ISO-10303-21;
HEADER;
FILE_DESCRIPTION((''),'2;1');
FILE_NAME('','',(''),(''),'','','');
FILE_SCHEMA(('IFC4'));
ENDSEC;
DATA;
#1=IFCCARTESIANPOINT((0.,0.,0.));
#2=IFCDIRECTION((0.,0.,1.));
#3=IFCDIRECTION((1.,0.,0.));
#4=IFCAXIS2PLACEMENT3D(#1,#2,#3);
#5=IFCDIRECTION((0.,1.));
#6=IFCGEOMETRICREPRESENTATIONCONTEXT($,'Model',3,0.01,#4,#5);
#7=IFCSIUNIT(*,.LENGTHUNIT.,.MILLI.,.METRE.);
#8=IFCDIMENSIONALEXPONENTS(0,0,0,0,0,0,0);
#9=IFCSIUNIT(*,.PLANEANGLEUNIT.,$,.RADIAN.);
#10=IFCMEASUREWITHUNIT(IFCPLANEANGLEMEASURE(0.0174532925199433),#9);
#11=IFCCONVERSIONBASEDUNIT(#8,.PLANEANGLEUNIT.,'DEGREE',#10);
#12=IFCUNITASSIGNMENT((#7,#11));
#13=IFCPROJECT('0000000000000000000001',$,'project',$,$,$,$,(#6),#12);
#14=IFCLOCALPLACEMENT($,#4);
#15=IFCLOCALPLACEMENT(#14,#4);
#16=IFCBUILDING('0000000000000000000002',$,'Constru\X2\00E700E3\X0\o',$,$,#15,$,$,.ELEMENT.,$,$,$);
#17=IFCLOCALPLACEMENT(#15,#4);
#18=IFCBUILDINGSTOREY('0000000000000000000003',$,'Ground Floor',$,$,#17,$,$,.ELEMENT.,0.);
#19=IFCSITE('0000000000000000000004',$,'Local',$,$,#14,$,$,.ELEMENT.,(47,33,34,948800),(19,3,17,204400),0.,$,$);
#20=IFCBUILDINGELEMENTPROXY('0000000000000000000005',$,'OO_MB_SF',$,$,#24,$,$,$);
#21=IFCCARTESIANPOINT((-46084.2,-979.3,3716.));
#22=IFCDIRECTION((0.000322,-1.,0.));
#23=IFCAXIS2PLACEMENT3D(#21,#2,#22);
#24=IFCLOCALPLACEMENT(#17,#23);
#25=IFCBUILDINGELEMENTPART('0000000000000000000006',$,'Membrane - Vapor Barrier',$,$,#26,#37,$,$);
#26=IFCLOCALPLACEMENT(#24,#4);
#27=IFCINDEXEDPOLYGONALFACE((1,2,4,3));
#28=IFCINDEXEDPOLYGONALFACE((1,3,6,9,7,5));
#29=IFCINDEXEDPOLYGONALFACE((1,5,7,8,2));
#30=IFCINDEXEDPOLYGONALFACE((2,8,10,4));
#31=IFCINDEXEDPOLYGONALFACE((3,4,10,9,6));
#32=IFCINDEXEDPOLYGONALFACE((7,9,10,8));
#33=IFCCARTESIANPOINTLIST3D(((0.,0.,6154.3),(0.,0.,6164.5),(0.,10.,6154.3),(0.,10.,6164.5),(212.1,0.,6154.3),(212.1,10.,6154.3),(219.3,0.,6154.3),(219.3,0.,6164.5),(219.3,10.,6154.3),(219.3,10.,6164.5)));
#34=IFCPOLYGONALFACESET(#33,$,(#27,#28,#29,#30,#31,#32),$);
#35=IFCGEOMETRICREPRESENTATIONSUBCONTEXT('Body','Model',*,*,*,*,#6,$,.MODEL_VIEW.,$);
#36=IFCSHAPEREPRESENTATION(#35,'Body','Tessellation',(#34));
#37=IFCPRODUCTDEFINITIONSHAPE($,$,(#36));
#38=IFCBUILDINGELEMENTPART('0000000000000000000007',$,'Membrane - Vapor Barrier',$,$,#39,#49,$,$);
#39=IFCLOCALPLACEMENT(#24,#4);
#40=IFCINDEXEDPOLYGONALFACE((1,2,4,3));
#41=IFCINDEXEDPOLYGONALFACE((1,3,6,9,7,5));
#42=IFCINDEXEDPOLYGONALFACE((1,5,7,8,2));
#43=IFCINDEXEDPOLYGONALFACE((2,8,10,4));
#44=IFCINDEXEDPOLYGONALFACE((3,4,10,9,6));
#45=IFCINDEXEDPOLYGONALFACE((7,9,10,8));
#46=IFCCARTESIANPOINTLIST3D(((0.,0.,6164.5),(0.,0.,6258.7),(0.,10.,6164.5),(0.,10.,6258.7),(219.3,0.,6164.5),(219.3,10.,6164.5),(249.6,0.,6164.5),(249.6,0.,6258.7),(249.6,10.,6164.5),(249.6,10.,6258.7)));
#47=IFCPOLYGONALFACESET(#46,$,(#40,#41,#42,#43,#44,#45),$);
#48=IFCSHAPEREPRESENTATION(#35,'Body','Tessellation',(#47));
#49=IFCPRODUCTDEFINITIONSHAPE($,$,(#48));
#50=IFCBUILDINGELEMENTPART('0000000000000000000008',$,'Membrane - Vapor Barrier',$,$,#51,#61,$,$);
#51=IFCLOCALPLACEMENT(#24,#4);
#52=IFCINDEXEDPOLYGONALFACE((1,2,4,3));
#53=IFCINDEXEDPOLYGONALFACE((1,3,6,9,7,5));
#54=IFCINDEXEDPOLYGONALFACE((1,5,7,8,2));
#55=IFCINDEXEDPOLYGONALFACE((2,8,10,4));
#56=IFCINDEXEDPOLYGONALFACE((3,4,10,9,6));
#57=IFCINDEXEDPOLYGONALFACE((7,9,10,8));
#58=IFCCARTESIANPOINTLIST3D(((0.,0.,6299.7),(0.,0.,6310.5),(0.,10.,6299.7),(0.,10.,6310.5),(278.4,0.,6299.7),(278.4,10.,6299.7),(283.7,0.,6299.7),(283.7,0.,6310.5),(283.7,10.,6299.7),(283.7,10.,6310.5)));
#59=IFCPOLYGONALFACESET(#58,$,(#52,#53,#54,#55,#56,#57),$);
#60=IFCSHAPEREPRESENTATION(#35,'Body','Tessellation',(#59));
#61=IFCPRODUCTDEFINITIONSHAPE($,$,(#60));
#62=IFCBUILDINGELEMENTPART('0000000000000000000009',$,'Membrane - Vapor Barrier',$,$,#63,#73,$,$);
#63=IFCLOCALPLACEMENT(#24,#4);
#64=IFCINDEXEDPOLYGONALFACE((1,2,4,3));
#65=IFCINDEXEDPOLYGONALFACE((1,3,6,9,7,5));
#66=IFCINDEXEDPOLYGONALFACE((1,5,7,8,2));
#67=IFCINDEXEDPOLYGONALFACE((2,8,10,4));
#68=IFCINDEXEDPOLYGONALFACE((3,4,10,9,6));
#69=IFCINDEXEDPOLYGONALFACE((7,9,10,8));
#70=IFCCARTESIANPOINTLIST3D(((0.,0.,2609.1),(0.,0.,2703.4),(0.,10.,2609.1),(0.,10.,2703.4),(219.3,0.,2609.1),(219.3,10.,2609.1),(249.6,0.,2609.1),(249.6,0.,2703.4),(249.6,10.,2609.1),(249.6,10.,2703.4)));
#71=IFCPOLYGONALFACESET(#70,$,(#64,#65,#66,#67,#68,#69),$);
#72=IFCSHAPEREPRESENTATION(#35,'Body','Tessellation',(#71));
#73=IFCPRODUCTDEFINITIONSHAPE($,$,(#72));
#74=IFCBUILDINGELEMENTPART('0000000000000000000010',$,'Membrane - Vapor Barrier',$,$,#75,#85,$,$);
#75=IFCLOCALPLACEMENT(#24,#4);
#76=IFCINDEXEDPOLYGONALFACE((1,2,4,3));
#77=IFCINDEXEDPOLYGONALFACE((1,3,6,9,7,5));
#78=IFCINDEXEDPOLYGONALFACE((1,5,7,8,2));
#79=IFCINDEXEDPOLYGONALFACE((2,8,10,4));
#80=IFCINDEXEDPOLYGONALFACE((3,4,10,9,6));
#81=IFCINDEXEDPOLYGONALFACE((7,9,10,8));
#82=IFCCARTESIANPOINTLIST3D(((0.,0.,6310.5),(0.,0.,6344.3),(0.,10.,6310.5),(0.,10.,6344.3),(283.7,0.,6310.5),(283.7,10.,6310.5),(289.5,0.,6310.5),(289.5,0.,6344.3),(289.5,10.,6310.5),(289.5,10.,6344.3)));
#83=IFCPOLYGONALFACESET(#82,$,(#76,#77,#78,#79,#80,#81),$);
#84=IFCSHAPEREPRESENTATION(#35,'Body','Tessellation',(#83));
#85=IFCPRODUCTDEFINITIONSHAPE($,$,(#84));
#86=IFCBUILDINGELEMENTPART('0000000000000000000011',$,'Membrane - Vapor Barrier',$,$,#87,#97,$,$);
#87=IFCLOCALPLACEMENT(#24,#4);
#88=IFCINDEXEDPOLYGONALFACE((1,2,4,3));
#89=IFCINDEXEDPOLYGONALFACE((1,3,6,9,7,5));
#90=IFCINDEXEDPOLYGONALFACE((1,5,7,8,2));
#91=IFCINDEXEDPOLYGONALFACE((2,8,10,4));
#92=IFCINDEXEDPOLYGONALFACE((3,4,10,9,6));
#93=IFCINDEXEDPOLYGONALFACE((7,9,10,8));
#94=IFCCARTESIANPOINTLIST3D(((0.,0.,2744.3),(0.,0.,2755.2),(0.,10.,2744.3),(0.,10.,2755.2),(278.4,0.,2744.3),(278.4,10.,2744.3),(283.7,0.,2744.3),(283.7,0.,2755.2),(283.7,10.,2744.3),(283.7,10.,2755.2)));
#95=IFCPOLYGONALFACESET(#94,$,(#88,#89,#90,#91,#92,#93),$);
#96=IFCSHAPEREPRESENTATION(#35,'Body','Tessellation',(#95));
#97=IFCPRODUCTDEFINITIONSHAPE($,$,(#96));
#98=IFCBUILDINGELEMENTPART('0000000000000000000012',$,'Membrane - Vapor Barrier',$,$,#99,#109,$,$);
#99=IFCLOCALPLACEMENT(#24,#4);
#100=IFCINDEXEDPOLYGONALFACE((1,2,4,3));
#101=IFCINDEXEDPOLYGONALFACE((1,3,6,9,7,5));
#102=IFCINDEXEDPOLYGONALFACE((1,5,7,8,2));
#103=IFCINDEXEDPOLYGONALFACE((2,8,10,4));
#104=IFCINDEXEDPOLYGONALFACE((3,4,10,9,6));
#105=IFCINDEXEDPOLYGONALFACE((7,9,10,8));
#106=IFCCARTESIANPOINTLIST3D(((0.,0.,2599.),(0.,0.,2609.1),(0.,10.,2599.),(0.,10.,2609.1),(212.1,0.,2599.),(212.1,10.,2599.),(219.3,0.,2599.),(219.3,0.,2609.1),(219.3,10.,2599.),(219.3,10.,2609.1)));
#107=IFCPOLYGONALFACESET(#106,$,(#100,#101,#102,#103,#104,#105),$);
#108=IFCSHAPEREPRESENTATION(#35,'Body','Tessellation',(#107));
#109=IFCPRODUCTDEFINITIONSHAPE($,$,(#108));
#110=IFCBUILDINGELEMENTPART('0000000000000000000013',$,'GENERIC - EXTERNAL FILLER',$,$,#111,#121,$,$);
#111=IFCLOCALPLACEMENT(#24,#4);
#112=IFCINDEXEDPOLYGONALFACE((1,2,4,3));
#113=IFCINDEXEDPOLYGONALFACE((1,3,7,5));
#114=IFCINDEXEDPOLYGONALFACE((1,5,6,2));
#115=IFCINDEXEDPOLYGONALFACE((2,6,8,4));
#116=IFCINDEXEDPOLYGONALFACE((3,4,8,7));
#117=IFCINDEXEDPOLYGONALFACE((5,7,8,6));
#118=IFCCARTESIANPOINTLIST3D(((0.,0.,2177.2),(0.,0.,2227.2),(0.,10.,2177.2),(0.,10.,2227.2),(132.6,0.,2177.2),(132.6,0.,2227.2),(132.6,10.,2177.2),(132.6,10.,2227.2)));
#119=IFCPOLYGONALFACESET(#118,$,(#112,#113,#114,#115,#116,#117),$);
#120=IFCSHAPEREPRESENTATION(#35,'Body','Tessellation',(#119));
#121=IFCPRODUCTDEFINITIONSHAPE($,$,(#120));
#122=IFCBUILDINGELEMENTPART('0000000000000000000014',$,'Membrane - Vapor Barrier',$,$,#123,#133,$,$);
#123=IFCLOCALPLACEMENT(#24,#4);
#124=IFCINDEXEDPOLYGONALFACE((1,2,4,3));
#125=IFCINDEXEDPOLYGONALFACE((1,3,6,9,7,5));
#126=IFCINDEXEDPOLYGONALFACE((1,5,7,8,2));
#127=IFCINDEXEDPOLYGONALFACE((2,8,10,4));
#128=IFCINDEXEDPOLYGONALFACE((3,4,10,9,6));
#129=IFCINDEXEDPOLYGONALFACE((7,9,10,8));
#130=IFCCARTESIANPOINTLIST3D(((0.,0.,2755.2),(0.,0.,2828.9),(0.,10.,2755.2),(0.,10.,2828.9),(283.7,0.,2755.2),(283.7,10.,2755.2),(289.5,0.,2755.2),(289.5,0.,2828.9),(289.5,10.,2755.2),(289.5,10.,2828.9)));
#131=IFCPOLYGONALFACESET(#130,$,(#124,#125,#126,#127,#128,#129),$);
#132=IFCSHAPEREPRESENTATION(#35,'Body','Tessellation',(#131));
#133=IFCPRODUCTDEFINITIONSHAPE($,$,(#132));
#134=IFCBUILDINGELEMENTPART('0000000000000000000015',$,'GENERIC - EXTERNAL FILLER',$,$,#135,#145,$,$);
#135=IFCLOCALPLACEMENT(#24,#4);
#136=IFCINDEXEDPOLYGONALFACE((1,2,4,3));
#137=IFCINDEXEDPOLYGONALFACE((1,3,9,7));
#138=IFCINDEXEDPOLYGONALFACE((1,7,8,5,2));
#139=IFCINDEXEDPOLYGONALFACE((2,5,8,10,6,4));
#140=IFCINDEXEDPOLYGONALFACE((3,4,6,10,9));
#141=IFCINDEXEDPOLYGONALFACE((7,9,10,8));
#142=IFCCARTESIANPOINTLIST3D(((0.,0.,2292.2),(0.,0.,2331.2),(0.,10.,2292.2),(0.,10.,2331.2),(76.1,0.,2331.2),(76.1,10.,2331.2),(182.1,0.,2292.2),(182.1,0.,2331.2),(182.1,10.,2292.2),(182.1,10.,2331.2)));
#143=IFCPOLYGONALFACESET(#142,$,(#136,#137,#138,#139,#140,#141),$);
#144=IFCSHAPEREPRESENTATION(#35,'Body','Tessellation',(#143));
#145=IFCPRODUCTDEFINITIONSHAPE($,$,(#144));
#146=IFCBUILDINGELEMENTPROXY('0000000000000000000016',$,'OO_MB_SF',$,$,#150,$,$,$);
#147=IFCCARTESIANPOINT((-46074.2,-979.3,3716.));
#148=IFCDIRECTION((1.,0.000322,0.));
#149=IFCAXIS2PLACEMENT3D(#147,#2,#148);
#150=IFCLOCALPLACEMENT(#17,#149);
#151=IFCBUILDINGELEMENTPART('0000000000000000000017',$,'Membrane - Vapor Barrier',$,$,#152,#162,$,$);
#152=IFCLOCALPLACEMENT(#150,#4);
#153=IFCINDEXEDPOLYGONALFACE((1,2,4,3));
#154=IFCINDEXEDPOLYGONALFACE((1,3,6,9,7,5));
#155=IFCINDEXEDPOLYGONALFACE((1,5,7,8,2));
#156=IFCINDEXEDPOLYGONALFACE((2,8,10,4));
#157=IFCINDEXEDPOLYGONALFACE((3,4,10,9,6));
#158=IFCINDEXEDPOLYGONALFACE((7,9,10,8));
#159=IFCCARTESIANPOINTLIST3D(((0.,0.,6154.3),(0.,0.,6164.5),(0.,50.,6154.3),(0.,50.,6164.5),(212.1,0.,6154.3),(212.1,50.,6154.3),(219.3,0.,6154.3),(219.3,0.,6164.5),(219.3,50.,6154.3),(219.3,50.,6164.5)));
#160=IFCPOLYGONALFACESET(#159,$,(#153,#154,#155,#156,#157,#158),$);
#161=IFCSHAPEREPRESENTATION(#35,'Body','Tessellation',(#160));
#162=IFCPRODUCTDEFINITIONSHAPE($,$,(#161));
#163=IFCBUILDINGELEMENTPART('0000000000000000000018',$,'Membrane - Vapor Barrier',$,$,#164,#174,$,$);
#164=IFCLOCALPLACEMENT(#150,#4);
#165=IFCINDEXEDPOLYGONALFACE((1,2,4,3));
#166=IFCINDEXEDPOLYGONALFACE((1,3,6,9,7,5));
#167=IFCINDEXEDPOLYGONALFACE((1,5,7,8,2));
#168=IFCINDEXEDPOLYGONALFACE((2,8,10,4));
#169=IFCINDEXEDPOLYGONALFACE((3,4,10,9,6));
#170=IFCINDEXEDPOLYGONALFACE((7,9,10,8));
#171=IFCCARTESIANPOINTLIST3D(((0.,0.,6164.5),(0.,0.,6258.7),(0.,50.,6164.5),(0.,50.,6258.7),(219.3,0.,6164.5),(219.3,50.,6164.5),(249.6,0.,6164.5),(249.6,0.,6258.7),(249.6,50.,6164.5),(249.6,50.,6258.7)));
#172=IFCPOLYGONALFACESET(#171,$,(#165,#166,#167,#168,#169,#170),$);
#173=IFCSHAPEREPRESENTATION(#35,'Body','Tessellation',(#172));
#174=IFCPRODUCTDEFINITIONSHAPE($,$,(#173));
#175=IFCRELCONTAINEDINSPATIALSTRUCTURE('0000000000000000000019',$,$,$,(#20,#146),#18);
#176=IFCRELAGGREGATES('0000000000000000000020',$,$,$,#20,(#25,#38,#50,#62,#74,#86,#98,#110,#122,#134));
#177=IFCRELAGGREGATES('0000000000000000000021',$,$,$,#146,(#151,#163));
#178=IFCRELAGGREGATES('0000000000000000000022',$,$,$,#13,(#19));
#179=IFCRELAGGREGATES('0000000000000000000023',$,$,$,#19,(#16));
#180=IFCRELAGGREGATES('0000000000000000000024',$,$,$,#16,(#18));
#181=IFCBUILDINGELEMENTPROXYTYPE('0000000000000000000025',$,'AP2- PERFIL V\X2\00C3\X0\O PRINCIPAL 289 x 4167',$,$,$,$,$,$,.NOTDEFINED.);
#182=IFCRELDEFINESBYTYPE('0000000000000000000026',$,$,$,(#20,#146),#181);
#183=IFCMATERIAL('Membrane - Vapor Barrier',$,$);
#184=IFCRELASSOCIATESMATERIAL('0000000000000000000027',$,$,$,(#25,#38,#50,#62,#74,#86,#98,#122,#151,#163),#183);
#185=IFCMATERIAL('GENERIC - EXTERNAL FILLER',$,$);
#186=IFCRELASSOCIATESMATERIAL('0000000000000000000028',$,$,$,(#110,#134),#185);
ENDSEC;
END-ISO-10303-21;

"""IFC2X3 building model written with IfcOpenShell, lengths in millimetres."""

from ifc_helpers import new_model, entity, si_unit, converted_unit, direction, frame, origin_with_axes, place, context, subcontext, project, spatial, polyline, outline, extrude, material, type_object, element, aggregate, save


model = new_model("IFC2X3")

# Units and contexts
model_context = context("Model", 3, precision=0.01, world=origin_with_axes(), true_north=direction((0.0, 1.0)))
body_context = subcontext(model_context, "Body", "Model", "MODEL_VIEW")
ifc_project = project(units=[si_unit("LENGTHUNIT", "METRE", prefix="MILLI"), converted_unit("PLANEANGLEUNIT", "DEGREE", entity("IfcPlaneAngleMeasure", 0.0174532925199433), si_unit("PLANEANGLEUNIT", "RADIAN"), dimensions=[0, 0, 0, 0, 0, 0, 0])], contexts=[model_context])

# Site, building, storey
site_placement = place(None, origin_with_axes())
site = spatial("IfcSite", under=ifc_project, at=site_placement, Name="Local", CompositionType="ELEMENT", RefLatitude=(47, 33, 34, 948800), RefLongitude=(19, 3, 17, 204400), RefElevation=0.0)
building_placement = place(site_placement, origin_with_axes())
building = spatial("IfcBuilding", under=site, at=building_placement, Name="Construção", CompositionType="ELEMENT")
storey_placement = place(building_placement, origin_with_axes())
storey = spatial("IfcBuildingStorey", under=building, at=storey_placement, Name="Ground Floor", CompositionType="ELEMENT", Elevation=0.0)

# Building element proxies, building element parts
building_element_proxy_type_1 = type_object("IfcBuildingElementProxyType", Name="AP2- PERFIL VÃO PRINCIPAL 289 x 4167", PredefinedType="NOTDEFINED")
proxy_1_placement = place(storey_placement, frame((-46084.2, -979.3, 3716.0), z_axis=(0.0, 0.0, 1.0), x_axis=(0.000322, -1.0, 0.0)))
proxy_1 = element("IfcBuildingElementProxy", 1, at=proxy_1_placement, inside=storey, type_object=building_element_proxy_type_1, Name="OO_MB_SF")
ifc_material_1 = material(Name="Membrane - Vapor Barrier")
building_element_part_1_placement = place(proxy_1_placement, origin_with_axes())
building_element_part_1 = element("IfcBuildingElementPart", 2, at=building_element_part_1_placement, material=ifc_material_1, Name="Membrane - Vapor Barrier", context=body_context, shape_type="SweptSolid", body=[
    extrude(outline(polyline([(0.0, 6154.3), (212.1, 6154.3), (219.3, 6154.3), (219.3, 6164.5), (0.0, 6164.5), (0.0, 6154.3)])), frame((0.0, 10.0, 0.0), z_axis=(0.0, -1.0, 0.0), x_axis=(1.0, 0.0, 0.0)), (0.0, 0.0, 1.0), 10.0),
])
building_element_part_2_placement = place(proxy_1_placement, origin_with_axes())
building_element_part_2 = element("IfcBuildingElementPart", 3, at=building_element_part_2_placement, material=ifc_material_1, Name="Membrane - Vapor Barrier", context=body_context, shape_type="SweptSolid", body=[
    extrude(outline(polyline([(249.6, 6258.7), (0.0, 6258.7), (0.0, 6164.5), (219.3, 6164.5), (249.6, 6164.5), (249.6, 6258.7)])), frame((0.0, 10.0, 0.0), z_axis=(0.0, -1.0, 0.0), x_axis=(1.0, 0.0, 0.0)), (0.0, 0.0, 1.0), 10.0),
])
building_element_part_3_placement = place(proxy_1_placement, origin_with_axes())
building_element_part_3 = element("IfcBuildingElementPart", 4, at=building_element_part_3_placement, material=ifc_material_1, Name="Membrane - Vapor Barrier", context=body_context, shape_type="SweptSolid", body=[
    extrude(outline(polyline([(0.0, 6299.7), (278.4, 6299.7), (283.7, 6299.7), (283.7, 6310.5), (0.0, 6310.5), (0.0, 6299.7)])), frame((0.0, 10.0, 0.0), z_axis=(0.0, -1.0, 0.0), x_axis=(1.0, 0.0, 0.0)), (0.0, 0.0, 1.0), 10.0),
])
building_element_part_4_placement = place(proxy_1_placement, origin_with_axes())
building_element_part_4 = element("IfcBuildingElementPart", 5, at=building_element_part_4_placement, material=ifc_material_1, Name="Membrane - Vapor Barrier", context=body_context, shape_type="SweptSolid", body=[
    extrude(outline(polyline([(249.6, 2703.4), (0.0, 2703.4), (0.0, 2609.1), (219.3, 2609.1), (249.6, 2609.1), (249.6, 2703.4)])), frame((0.0, 10.0, 0.0), z_axis=(0.0, -1.0, 0.0), x_axis=(1.0, 0.0, 0.0)), (0.0, 0.0, 1.0), 10.0),
])
building_element_part_5_placement = place(proxy_1_placement, origin_with_axes())
building_element_part_5 = element("IfcBuildingElementPart", 6, at=building_element_part_5_placement, material=ifc_material_1, Name="Membrane - Vapor Barrier", context=body_context, shape_type="SweptSolid", body=[
    extrude(outline(polyline([(0.0, 6310.5), (283.7, 6310.5), (289.5, 6310.5), (289.5, 6344.3), (0.0, 6344.3), (0.0, 6310.5)])), frame((0.0, 10.0, 0.0), z_axis=(0.0, -1.0, 0.0), x_axis=(1.0, 0.0, 0.0)), (0.0, 0.0, 1.0), 10.0),
])
building_element_part_6_placement = place(proxy_1_placement, origin_with_axes())
building_element_part_6 = element("IfcBuildingElementPart", 7, at=building_element_part_6_placement, material=ifc_material_1, Name="Membrane - Vapor Barrier", context=body_context, shape_type="SweptSolid", body=[
    extrude(outline(polyline([(0.0, 2744.3), (278.4, 2744.3), (283.7, 2744.3), (283.7, 2755.2), (0.0, 2755.2), (0.0, 2744.3)])), frame((0.0, 10.0, 0.0), z_axis=(0.0, -1.0, 0.0), x_axis=(1.0, 0.0, 0.0)), (0.0, 0.0, 1.0), 10.0),
])
building_element_part_7_placement = place(proxy_1_placement, origin_with_axes())
building_element_part_7 = element("IfcBuildingElementPart", 8, at=building_element_part_7_placement, material=ifc_material_1, Name="Membrane - Vapor Barrier", context=body_context, shape_type="SweptSolid", body=[
    extrude(outline(polyline([(0.0, 2599.0), (212.1, 2599.0), (219.3, 2599.0), (219.3, 2609.1), (0.0, 2609.1), (0.0, 2599.0)])), frame((0.0, 10.0, 0.0), z_axis=(0.0, -1.0, 0.0), x_axis=(1.0, 0.0, 0.0)), (0.0, 0.0, 1.0), 10.0),
])
ifc_material_2 = material(Name="GENERIC - EXTERNAL FILLER")
building_element_part_8_placement = place(proxy_1_placement, origin_with_axes())
building_element_part_8 = element("IfcBuildingElementPart", 9, at=building_element_part_8_placement, material=ifc_material_2, Name="GENERIC - EXTERNAL FILLER", context=body_context, shape_type="SweptSolid", body=[
    extrude(outline(polyline([(0.0, 2227.2), (0.0, 2177.2), (132.6, 2177.2), (132.6, 2227.2), (0.0, 2227.2)])), frame((0.0, 10.0, 0.0), z_axis=(0.0, -1.0, 0.0), x_axis=(1.0, 0.0, 0.0)), (0.0, 0.0, 1.0), 10.0),
])
building_element_part_9_placement = place(proxy_1_placement, origin_with_axes())
building_element_part_9 = element("IfcBuildingElementPart", 10, at=building_element_part_9_placement, material=ifc_material_1, Name="Membrane - Vapor Barrier", context=body_context, shape_type="SweptSolid", body=[
    extrude(outline(polyline([(0.0, 2755.2), (283.7, 2755.2), (289.5, 2755.2), (289.5, 2828.9), (0.0, 2828.9), (0.0, 2755.2)])), frame((0.0, 10.0, 0.0), z_axis=(0.0, -1.0, 0.0), x_axis=(1.0, 0.0, 0.0)), (0.0, 0.0, 1.0), 10.0),
])
building_element_part_10_placement = place(proxy_1_placement, origin_with_axes())
building_element_part_10 = element("IfcBuildingElementPart", 11, at=building_element_part_10_placement, material=ifc_material_2, Name="GENERIC - EXTERNAL FILLER", context=body_context, shape_type="SweptSolid", body=[
    extrude(outline(polyline([(0.0, 2331.2), (0.0, 2292.2), (182.1, 2292.2), (182.1, 2331.2), (76.1, 2331.2), (0.0, 2331.2)])), frame((0.0, 10.0, 0.0), z_axis=(0.0, -1.0, 0.0), x_axis=(1.0, 0.0, 0.0)), (0.0, 0.0, 1.0), 10.0),
])
aggregate(proxy_1, [building_element_part_1, building_element_part_2, building_element_part_3, building_element_part_4, building_element_part_5, building_element_part_6, building_element_part_7, building_element_part_8, building_element_part_9, building_element_part_10])
proxy_2_placement = place(storey_placement, frame((-46074.2, -979.3, 3716.0), z_axis=(0.0, 0.0, 1.0), x_axis=(1.0, 0.000322, 0.0)))
proxy_2 = element("IfcBuildingElementProxy", 12, at=proxy_2_placement, inside=storey, type_object=building_element_proxy_type_1, Name="OO_MB_SF")
building_element_part_11_placement = place(proxy_2_placement, origin_with_axes())
building_element_part_11 = element("IfcBuildingElementPart", 13, at=building_element_part_11_placement, material=ifc_material_1, Name="Membrane - Vapor Barrier", context=body_context, shape_type="SweptSolid", body=[
    extrude(outline(polyline([(0.0, 6154.3), (212.1, 6154.3), (219.3, 6154.3), (219.3, 6164.5), (0.0, 6164.5), (0.0, 6154.3)])), frame((0.0, 50.0, 0.0), z_axis=(0.0, -1.0, 0.0), x_axis=(1.0, 0.0, 0.0)), (0.0, 0.0, 1.0), 50.0),
])
building_element_part_12_placement = place(proxy_2_placement, origin_with_axes())
building_element_part_12 = element("IfcBuildingElementPart", 14, at=building_element_part_12_placement, material=ifc_material_1, Name="Membrane - Vapor Barrier", context=body_context, shape_type="SweptSolid", body=[
    extrude(outline(polyline([(249.6, 6258.7), (0.0, 6258.7), (0.0, 6164.5), (219.3, 6164.5), (249.6, 6164.5), (249.6, 6258.7)])), frame((0.0, 50.0, 0.0), z_axis=(0.0, -1.0, 0.0), x_axis=(1.0, 0.0, 0.0)), (0.0, 0.0, 1.0), 50.0),
])
aggregate(proxy_2, [building_element_part_11, building_element_part_12])

save(model, "model.ifc")
